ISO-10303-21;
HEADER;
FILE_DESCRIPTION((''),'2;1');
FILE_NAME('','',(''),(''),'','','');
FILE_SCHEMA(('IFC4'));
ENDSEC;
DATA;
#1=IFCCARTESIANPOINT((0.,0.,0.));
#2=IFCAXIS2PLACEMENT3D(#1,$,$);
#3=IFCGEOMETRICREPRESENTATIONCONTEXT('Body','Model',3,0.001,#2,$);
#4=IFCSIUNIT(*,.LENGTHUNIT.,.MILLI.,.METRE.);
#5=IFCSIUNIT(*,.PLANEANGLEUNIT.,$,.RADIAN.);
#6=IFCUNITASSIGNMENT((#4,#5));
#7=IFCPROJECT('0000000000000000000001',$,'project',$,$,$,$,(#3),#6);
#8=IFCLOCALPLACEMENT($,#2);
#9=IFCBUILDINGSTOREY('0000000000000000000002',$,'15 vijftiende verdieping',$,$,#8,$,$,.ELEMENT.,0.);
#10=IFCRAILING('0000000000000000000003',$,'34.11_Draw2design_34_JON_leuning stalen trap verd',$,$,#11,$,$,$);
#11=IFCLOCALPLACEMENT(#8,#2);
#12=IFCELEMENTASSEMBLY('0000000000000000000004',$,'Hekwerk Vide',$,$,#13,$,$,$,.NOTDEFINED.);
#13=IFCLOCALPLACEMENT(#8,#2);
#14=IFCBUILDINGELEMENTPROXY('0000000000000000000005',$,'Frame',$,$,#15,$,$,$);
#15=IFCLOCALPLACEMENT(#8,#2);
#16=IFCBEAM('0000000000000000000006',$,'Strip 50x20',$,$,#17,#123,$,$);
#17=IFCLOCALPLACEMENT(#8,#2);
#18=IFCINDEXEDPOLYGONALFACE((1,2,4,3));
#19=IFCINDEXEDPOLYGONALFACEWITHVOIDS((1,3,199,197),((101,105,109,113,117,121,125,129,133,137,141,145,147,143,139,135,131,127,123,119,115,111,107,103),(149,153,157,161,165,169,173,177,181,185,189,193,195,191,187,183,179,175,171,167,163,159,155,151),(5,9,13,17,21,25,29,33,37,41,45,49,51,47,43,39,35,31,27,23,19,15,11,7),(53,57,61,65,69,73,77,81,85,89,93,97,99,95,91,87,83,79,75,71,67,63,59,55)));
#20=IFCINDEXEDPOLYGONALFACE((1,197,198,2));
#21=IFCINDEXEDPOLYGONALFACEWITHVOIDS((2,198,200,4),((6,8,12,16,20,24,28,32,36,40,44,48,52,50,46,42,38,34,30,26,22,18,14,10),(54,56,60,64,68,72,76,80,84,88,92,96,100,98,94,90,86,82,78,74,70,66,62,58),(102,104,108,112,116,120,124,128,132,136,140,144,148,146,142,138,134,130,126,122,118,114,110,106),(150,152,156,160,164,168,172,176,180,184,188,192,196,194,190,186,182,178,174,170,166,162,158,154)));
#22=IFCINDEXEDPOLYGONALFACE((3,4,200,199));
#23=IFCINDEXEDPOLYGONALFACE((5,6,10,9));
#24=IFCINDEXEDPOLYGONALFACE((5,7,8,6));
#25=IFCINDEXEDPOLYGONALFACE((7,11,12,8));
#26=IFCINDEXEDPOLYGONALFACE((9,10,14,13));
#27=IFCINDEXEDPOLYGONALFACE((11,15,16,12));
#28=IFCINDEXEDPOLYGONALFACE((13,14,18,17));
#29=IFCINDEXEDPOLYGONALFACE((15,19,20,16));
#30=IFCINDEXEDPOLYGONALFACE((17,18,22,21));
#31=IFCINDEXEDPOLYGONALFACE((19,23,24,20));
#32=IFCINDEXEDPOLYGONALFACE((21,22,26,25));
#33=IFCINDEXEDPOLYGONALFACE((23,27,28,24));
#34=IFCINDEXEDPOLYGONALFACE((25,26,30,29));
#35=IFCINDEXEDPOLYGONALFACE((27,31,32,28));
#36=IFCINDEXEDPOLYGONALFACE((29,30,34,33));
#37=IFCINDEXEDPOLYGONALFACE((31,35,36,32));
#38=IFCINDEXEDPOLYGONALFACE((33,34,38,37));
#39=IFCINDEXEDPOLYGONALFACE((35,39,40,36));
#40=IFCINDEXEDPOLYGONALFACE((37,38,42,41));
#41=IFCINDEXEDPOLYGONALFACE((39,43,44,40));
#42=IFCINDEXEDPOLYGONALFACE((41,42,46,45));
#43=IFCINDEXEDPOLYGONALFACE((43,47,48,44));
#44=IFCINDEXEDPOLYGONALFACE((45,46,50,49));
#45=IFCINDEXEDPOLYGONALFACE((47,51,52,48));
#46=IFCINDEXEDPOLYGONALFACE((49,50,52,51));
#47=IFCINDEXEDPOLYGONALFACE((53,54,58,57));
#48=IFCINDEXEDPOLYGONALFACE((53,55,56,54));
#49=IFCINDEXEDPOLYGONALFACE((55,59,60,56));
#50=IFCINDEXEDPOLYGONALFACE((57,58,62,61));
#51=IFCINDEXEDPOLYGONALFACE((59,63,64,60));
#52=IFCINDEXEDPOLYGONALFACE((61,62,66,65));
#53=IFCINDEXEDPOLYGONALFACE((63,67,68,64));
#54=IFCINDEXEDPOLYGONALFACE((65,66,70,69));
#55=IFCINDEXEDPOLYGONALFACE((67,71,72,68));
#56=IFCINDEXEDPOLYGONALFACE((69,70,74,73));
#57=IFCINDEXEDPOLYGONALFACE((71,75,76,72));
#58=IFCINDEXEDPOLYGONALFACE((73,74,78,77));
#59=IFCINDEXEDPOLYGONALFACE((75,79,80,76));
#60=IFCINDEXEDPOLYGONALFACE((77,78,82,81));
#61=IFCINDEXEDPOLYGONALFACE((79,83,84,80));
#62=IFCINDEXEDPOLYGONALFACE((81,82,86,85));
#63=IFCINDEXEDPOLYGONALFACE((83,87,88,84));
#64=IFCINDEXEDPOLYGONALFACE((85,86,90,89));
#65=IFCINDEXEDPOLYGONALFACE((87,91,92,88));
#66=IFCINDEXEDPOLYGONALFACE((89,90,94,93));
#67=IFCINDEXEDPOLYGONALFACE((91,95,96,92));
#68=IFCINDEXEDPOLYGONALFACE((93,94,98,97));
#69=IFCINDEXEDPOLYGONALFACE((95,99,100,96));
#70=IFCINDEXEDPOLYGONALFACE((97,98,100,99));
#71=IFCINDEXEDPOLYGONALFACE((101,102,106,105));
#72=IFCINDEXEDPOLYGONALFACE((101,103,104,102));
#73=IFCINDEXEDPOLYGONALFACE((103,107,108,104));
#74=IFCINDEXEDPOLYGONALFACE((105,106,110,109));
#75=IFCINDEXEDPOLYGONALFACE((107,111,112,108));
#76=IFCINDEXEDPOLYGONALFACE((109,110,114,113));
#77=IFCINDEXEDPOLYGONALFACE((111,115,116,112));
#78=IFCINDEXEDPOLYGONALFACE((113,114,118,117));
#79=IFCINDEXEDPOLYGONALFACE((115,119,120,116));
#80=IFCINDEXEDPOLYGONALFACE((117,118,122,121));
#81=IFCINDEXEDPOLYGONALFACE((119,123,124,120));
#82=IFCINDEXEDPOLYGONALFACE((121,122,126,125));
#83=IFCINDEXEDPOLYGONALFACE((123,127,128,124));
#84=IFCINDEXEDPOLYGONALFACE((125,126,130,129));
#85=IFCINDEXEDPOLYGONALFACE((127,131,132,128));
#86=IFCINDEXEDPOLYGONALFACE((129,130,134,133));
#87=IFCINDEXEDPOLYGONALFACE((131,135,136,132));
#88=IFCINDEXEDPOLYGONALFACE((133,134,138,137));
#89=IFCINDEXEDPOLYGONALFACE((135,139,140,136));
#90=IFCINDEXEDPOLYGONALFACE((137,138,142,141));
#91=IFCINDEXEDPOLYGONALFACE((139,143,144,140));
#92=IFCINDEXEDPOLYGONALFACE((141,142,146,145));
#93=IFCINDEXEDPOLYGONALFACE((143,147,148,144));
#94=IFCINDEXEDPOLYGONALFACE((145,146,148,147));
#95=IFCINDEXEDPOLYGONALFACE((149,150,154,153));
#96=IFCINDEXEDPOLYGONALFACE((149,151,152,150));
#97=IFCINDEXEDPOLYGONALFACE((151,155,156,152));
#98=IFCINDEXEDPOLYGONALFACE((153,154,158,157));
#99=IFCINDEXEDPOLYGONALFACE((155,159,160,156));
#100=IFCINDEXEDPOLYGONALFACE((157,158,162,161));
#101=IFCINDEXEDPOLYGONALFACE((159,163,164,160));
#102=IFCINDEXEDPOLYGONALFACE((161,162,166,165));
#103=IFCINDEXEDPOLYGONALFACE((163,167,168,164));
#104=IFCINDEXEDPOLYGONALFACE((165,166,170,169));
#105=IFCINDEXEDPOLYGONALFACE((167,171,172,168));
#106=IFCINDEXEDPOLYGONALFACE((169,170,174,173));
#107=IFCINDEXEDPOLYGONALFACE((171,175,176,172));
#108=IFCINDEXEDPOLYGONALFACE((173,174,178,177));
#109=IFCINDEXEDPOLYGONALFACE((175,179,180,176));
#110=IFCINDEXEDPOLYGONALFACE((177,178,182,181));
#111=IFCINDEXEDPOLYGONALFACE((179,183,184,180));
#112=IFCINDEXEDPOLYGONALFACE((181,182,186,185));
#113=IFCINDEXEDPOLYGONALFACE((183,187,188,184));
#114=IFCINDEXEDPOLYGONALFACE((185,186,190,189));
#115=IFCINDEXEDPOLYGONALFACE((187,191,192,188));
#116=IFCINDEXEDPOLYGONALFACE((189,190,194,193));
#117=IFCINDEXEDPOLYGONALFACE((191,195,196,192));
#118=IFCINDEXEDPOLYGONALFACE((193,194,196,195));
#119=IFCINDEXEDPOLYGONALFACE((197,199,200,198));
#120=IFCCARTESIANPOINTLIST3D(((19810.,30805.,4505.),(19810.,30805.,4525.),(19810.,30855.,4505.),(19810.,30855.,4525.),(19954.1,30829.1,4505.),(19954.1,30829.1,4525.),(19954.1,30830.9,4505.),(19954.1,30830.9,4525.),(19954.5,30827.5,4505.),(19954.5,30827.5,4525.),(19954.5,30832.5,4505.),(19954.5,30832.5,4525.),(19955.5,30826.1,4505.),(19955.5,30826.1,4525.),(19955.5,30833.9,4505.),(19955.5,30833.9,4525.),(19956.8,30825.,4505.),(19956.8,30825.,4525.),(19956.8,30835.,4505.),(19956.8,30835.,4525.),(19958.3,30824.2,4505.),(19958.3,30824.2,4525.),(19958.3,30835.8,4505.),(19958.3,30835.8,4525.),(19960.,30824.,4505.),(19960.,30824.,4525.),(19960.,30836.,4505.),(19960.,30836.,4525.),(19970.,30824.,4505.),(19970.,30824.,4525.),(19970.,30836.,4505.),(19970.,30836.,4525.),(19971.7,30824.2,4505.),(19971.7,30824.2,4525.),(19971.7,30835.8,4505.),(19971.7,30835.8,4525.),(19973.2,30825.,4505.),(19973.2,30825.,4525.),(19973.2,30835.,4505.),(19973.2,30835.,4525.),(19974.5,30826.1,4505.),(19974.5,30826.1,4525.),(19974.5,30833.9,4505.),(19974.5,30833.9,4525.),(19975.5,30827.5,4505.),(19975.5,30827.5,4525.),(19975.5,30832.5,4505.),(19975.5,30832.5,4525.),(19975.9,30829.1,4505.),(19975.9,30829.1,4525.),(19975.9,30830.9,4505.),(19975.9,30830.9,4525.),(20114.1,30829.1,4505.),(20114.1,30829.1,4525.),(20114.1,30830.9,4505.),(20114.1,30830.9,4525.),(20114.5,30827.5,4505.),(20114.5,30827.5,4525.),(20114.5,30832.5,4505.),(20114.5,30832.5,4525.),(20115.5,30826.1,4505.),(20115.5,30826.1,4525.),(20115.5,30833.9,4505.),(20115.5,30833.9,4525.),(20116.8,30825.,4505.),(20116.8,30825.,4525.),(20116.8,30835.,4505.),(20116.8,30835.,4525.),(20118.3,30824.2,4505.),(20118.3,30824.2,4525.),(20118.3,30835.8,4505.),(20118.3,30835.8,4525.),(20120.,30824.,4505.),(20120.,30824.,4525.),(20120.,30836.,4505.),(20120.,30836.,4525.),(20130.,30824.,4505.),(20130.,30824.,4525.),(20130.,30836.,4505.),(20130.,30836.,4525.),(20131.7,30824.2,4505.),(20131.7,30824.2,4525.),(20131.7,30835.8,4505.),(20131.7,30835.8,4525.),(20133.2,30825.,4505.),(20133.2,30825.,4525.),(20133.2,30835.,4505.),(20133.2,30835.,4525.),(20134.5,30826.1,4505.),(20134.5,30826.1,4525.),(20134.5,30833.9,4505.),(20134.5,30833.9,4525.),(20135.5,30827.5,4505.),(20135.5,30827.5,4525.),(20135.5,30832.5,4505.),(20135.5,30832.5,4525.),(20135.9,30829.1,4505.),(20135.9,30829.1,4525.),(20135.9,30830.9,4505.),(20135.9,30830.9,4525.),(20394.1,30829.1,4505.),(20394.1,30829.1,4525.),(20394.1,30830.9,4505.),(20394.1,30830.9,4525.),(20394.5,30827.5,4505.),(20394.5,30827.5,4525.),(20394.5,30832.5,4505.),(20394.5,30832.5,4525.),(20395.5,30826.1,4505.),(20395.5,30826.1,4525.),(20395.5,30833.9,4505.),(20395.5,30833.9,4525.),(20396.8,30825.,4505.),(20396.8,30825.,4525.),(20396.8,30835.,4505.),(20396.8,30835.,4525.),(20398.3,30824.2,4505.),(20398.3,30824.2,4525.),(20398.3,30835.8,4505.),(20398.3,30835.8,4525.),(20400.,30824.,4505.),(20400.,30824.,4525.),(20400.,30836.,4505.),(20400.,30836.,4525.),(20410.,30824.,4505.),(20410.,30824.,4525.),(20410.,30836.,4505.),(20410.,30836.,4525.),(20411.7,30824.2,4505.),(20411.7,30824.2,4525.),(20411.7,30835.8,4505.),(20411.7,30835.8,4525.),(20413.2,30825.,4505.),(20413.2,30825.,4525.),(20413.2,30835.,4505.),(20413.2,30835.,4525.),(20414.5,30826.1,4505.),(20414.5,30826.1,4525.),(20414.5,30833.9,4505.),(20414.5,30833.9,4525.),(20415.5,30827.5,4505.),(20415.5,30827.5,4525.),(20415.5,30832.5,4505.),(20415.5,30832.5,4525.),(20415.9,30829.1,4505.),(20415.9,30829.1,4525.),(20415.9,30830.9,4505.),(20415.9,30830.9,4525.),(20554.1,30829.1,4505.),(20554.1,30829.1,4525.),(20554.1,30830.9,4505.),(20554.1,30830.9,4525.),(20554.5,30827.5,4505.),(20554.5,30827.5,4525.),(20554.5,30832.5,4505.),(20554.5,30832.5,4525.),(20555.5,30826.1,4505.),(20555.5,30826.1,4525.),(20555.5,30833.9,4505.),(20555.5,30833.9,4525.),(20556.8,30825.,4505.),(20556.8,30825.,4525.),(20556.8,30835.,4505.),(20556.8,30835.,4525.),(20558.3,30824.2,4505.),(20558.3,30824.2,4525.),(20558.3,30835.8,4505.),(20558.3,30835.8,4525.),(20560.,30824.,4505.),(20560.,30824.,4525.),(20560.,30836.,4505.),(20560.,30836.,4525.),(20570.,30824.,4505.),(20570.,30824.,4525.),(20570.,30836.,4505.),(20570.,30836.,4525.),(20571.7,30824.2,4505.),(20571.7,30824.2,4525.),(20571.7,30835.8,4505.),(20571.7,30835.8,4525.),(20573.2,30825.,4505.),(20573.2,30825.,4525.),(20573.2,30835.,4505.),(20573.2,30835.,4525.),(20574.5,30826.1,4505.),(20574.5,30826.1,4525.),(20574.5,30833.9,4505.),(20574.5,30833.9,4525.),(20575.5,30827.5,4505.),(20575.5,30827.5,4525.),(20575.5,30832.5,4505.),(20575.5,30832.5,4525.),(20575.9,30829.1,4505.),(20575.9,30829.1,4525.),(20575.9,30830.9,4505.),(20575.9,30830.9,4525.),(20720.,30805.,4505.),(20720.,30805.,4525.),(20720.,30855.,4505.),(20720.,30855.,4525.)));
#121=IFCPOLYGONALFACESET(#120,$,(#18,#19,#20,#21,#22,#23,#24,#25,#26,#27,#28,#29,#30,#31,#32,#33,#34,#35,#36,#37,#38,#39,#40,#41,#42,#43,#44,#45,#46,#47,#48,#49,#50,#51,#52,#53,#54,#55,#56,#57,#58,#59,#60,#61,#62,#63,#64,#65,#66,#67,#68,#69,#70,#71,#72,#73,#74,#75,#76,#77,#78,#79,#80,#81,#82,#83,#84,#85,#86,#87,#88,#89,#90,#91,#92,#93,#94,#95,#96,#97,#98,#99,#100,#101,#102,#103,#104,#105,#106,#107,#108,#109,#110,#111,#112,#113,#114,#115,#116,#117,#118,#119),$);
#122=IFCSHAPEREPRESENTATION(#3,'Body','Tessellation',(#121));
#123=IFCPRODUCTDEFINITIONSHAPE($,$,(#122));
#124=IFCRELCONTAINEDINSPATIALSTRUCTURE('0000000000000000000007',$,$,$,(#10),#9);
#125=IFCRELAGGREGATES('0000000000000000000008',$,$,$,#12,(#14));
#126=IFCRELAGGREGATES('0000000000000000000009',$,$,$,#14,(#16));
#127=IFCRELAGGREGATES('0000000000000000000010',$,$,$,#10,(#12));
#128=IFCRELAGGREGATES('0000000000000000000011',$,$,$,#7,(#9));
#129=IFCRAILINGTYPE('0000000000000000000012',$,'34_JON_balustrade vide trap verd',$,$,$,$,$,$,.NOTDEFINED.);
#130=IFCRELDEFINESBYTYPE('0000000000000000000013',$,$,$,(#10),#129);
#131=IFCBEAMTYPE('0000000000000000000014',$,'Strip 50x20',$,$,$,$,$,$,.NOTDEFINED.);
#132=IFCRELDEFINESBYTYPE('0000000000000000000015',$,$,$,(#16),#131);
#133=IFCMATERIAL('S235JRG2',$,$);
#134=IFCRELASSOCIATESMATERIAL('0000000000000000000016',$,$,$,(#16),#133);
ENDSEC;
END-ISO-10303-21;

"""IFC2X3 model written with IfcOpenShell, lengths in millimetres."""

from ifc_helpers import new_model, si_unit, point, frame, frame_2d, origin, origin_2d, place, context, project, spatial, circle_curve, line_curve, trimmed, segment, composite_curve, rectangle, outline, extrude, source, transform, mapped, material, type_object, element, aggregate, save


model = new_model("IFC2X3")

# Units and contexts
model_context = context("Model", 3, precision=0.001, world=origin(), identifier="Body")
ifc_project = project(units=[si_unit("LENGTHUNIT", "METRE", prefix="MILLI"), si_unit("PLANEANGLEUNIT", "RADIAN")], contexts=[model_context])

# Storey
storey_placement = place(None, origin())
storey = spatial("IfcBuildingStorey", under=ifc_project, at=storey_placement, Name="15 vijftiende verdieping", CompositionType="ELEMENT", Elevation=0.0)

# Railing, element assembly, building element proxy, beam, openings
railing_type = type_object("IfcRailingType", Name="34_JON_balustrade vide trap verd")
railing_placement = place(storey_placement, frame((-24393.0, 51609.5, -44800.0), z_axis=(0.0, 0.0, 1.0), x_axis=(0.0, -1.0, 0.0)))
railing = element("IfcRailing", 1, at=railing_placement, inside=storey, type_object=railing_type, Name="34.11_Draw2design_34_JON_leuning stalen trap verd")
assembly_placement = place(railing_placement, origin())
assembly = element("IfcElementAssembly", 2, at=assembly_placement, Name="Hekwerk Vide", PredefinedType="NOTDEFINED")
ifc_material_1 = material(Name="S235JRG2")
proxy_1_placement = place(assembly_placement, origin())
proxy_1 = element("IfcBuildingElementProxy", 3, at=proxy_1_placement, Name="Frame")
aggregate(assembly, [proxy_1])
beam_type_1 = type_object("IfcBeamType", Name="Strip 50x20")
shared_shape_1 = source(origin(), model_context, "Body", "SweptSolid", [
    extrude(rectangle(XDim=20.0, YDim=50.0, at=origin_2d()), origin(), (0.0, 0.0, -1.0), 910.0),
])
beam_1_placement = place(proxy_1_placement, frame((20779.5, 45113.0, 49315.0), z_axis=(0.0, 1.0, 0.0), x_axis=(0.0, 0.0, 1.0)))
beam_1 = element("IfcBeam", 4, at=beam_1_placement, type_object=beam_type_1, material=ifc_material_1, Name="Strip 50x20", context=model_context, shape_type="MappedRepresentation", body=[
    mapped(shared_shape_1, transform((0.0, 0.0, 0.0), scale=1.0)),
])
opening_1_placement = place(beam_1_placement, frame((10.0, 0.0, -595.0), z_axis=(-1.0, 0.0, 0.0), x_axis=(0.0, 0.0, 1.0)))
element("IfcOpeningElement", 5, at=opening_1_placement, cuts=beam_1, ObjectType="Opening", context=model_context, shape_type="SweptSolid", body=[
    extrude(outline(composite_curve([segment(trimmed(circle_curve(frame_2d((5.0, 0.0), x_axis=(0.0, -1.0)), 6.0), [point((5.0, 6.0))], [point((5.0, -6.0))], False, "CARTESIAN"), True, "CONTINUOUS"), segment(trimmed(line_curve((5.0, -6.0), (-10.0, 0.0), 10.0), [point((5.0, -6.0))], [point((-5.0, -6.0))], True, "CARTESIAN"), True, "CONTINUOUS"), segment(trimmed(circle_curve(frame_2d((-5.0, 0.0), x_axis=(0.0, -1.0)), 6.0), [point((-5.0, -6.0))], [point((-5.0, 6.0))], False, "CARTESIAN"), True, "CONTINUOUS"), segment(trimmed(line_curve((-5.0, 6.0), (10.0, 0.0), 10.0), [point((-5.0, 6.0))], [point((5.0, 6.0))], True, "CARTESIAN"), True, "CONTINUOUS")], self_intersect=False)), origin(), (0.0, 0.0, 1.0), 20.0),
])
opening_2_placement = place(beam_1_placement, frame((10.0, 0.0, -755.0), z_axis=(-1.0, 0.0, 0.0), x_axis=(0.0, 0.0, 1.0)))
element("IfcOpeningElement", 6, at=opening_2_placement, cuts=beam_1, ObjectType="Opening", context=model_context, shape_type="SweptSolid", body=[
    extrude(outline(composite_curve([segment(trimmed(circle_curve(frame_2d((5.0, 0.0), x_axis=(0.0, -1.0)), 6.0), [point((5.0, 6.0))], [point((5.0, -6.0))], False, "CARTESIAN"), True, "CONTINUOUS"), segment(trimmed(line_curve((5.0, -6.0), (-10.0, 0.0), 10.0), [point((5.0, -6.0))], [point((-5.0, -6.0))], True, "CARTESIAN"), True, "CONTINUOUS"), segment(trimmed(circle_curve(frame_2d((-5.0, 0.0), x_axis=(0.0, -1.0)), 6.0), [point((-5.0, -6.0))], [point((-5.0, 6.0))], False, "CARTESIAN"), True, "CONTINUOUS"), segment(trimmed(line_curve((-5.0, 6.0), (10.0, 0.0), 10.0), [point((-5.0, 6.0))], [point((5.0, 6.0))], True, "CARTESIAN"), True, "CONTINUOUS")], self_intersect=False)), origin(), (0.0, 0.0, 1.0), 20.0),
])
opening_3_placement = place(beam_1_placement, frame((10.0, 0.0, -155.0), z_axis=(-1.0, 0.0, 0.0), x_axis=(0.0, 0.0, -1.0)))
element("IfcOpeningElement", 7, at=opening_3_placement, cuts=beam_1, ObjectType="Opening", context=model_context, shape_type="SweptSolid", body=[
    extrude(outline(composite_curve([segment(trimmed(circle_curve(frame_2d((5.0, 0.0), x_axis=(0.0, -1.0)), 6.0), [point((5.0, 6.0))], [point((5.0, -6.0))], False, "CARTESIAN"), True, "CONTINUOUS"), segment(trimmed(line_curve((5.0, -6.0), (-10.0, 0.0), 10.0), [point((5.0, -6.0))], [point((-5.0, -6.0))], True, "CARTESIAN"), True, "CONTINUOUS"), segment(trimmed(circle_curve(frame_2d((-5.0, 0.0), x_axis=(0.0, -1.0)), 6.0), [point((-5.0, -6.0))], [point((-5.0, 6.0))], False, "CARTESIAN"), True, "CONTINUOUS"), segment(trimmed(line_curve((-5.0, 6.0), (10.0, 0.0), 10.0), [point((-5.0, 6.0))], [point((5.0, 6.0))], True, "CARTESIAN"), True, "CONTINUOUS")], self_intersect=False)), origin(), (0.0, 0.0, 1.0), 20.0),
])
opening_4_placement = place(beam_1_placement, frame((10.0, 0.0, -315.0), z_axis=(-1.0, 0.0, 0.0), x_axis=(0.0, 0.0, -1.0)))
element("IfcOpeningElement", 8, at=opening_4_placement, cuts=beam_1, ObjectType="Opening", context=model_context, shape_type="SweptSolid", body=[
    extrude(outline(composite_curve([segment(trimmed(circle_curve(frame_2d((5.0, 0.0), x_axis=(0.0, -1.0)), 6.0), [point((5.0, 6.0))], [point((5.0, -6.0))], False, "CARTESIAN"), True, "CONTINUOUS"), segment(trimmed(line_curve((5.0, -6.0), (-10.0, 0.0), 10.0), [point((5.0, -6.0))], [point((-5.0, -6.0))], True, "CARTESIAN"), True, "CONTINUOUS"), segment(trimmed(circle_curve(frame_2d((-5.0, 0.0), x_axis=(0.0, -1.0)), 6.0), [point((-5.0, -6.0))], [point((-5.0, 6.0))], False, "CARTESIAN"), True, "CONTINUOUS"), segment(trimmed(line_curve((-5.0, 6.0), (10.0, 0.0), 10.0), [point((-5.0, 6.0))], [point((5.0, 6.0))], True, "CARTESIAN"), True, "CONTINUOUS")], self_intersect=False)), origin(), (0.0, 0.0, 1.0), 20.0),
])
aggregate(proxy_1, [beam_1])
aggregate(railing, [assembly])

save(model, "model.ifc")
